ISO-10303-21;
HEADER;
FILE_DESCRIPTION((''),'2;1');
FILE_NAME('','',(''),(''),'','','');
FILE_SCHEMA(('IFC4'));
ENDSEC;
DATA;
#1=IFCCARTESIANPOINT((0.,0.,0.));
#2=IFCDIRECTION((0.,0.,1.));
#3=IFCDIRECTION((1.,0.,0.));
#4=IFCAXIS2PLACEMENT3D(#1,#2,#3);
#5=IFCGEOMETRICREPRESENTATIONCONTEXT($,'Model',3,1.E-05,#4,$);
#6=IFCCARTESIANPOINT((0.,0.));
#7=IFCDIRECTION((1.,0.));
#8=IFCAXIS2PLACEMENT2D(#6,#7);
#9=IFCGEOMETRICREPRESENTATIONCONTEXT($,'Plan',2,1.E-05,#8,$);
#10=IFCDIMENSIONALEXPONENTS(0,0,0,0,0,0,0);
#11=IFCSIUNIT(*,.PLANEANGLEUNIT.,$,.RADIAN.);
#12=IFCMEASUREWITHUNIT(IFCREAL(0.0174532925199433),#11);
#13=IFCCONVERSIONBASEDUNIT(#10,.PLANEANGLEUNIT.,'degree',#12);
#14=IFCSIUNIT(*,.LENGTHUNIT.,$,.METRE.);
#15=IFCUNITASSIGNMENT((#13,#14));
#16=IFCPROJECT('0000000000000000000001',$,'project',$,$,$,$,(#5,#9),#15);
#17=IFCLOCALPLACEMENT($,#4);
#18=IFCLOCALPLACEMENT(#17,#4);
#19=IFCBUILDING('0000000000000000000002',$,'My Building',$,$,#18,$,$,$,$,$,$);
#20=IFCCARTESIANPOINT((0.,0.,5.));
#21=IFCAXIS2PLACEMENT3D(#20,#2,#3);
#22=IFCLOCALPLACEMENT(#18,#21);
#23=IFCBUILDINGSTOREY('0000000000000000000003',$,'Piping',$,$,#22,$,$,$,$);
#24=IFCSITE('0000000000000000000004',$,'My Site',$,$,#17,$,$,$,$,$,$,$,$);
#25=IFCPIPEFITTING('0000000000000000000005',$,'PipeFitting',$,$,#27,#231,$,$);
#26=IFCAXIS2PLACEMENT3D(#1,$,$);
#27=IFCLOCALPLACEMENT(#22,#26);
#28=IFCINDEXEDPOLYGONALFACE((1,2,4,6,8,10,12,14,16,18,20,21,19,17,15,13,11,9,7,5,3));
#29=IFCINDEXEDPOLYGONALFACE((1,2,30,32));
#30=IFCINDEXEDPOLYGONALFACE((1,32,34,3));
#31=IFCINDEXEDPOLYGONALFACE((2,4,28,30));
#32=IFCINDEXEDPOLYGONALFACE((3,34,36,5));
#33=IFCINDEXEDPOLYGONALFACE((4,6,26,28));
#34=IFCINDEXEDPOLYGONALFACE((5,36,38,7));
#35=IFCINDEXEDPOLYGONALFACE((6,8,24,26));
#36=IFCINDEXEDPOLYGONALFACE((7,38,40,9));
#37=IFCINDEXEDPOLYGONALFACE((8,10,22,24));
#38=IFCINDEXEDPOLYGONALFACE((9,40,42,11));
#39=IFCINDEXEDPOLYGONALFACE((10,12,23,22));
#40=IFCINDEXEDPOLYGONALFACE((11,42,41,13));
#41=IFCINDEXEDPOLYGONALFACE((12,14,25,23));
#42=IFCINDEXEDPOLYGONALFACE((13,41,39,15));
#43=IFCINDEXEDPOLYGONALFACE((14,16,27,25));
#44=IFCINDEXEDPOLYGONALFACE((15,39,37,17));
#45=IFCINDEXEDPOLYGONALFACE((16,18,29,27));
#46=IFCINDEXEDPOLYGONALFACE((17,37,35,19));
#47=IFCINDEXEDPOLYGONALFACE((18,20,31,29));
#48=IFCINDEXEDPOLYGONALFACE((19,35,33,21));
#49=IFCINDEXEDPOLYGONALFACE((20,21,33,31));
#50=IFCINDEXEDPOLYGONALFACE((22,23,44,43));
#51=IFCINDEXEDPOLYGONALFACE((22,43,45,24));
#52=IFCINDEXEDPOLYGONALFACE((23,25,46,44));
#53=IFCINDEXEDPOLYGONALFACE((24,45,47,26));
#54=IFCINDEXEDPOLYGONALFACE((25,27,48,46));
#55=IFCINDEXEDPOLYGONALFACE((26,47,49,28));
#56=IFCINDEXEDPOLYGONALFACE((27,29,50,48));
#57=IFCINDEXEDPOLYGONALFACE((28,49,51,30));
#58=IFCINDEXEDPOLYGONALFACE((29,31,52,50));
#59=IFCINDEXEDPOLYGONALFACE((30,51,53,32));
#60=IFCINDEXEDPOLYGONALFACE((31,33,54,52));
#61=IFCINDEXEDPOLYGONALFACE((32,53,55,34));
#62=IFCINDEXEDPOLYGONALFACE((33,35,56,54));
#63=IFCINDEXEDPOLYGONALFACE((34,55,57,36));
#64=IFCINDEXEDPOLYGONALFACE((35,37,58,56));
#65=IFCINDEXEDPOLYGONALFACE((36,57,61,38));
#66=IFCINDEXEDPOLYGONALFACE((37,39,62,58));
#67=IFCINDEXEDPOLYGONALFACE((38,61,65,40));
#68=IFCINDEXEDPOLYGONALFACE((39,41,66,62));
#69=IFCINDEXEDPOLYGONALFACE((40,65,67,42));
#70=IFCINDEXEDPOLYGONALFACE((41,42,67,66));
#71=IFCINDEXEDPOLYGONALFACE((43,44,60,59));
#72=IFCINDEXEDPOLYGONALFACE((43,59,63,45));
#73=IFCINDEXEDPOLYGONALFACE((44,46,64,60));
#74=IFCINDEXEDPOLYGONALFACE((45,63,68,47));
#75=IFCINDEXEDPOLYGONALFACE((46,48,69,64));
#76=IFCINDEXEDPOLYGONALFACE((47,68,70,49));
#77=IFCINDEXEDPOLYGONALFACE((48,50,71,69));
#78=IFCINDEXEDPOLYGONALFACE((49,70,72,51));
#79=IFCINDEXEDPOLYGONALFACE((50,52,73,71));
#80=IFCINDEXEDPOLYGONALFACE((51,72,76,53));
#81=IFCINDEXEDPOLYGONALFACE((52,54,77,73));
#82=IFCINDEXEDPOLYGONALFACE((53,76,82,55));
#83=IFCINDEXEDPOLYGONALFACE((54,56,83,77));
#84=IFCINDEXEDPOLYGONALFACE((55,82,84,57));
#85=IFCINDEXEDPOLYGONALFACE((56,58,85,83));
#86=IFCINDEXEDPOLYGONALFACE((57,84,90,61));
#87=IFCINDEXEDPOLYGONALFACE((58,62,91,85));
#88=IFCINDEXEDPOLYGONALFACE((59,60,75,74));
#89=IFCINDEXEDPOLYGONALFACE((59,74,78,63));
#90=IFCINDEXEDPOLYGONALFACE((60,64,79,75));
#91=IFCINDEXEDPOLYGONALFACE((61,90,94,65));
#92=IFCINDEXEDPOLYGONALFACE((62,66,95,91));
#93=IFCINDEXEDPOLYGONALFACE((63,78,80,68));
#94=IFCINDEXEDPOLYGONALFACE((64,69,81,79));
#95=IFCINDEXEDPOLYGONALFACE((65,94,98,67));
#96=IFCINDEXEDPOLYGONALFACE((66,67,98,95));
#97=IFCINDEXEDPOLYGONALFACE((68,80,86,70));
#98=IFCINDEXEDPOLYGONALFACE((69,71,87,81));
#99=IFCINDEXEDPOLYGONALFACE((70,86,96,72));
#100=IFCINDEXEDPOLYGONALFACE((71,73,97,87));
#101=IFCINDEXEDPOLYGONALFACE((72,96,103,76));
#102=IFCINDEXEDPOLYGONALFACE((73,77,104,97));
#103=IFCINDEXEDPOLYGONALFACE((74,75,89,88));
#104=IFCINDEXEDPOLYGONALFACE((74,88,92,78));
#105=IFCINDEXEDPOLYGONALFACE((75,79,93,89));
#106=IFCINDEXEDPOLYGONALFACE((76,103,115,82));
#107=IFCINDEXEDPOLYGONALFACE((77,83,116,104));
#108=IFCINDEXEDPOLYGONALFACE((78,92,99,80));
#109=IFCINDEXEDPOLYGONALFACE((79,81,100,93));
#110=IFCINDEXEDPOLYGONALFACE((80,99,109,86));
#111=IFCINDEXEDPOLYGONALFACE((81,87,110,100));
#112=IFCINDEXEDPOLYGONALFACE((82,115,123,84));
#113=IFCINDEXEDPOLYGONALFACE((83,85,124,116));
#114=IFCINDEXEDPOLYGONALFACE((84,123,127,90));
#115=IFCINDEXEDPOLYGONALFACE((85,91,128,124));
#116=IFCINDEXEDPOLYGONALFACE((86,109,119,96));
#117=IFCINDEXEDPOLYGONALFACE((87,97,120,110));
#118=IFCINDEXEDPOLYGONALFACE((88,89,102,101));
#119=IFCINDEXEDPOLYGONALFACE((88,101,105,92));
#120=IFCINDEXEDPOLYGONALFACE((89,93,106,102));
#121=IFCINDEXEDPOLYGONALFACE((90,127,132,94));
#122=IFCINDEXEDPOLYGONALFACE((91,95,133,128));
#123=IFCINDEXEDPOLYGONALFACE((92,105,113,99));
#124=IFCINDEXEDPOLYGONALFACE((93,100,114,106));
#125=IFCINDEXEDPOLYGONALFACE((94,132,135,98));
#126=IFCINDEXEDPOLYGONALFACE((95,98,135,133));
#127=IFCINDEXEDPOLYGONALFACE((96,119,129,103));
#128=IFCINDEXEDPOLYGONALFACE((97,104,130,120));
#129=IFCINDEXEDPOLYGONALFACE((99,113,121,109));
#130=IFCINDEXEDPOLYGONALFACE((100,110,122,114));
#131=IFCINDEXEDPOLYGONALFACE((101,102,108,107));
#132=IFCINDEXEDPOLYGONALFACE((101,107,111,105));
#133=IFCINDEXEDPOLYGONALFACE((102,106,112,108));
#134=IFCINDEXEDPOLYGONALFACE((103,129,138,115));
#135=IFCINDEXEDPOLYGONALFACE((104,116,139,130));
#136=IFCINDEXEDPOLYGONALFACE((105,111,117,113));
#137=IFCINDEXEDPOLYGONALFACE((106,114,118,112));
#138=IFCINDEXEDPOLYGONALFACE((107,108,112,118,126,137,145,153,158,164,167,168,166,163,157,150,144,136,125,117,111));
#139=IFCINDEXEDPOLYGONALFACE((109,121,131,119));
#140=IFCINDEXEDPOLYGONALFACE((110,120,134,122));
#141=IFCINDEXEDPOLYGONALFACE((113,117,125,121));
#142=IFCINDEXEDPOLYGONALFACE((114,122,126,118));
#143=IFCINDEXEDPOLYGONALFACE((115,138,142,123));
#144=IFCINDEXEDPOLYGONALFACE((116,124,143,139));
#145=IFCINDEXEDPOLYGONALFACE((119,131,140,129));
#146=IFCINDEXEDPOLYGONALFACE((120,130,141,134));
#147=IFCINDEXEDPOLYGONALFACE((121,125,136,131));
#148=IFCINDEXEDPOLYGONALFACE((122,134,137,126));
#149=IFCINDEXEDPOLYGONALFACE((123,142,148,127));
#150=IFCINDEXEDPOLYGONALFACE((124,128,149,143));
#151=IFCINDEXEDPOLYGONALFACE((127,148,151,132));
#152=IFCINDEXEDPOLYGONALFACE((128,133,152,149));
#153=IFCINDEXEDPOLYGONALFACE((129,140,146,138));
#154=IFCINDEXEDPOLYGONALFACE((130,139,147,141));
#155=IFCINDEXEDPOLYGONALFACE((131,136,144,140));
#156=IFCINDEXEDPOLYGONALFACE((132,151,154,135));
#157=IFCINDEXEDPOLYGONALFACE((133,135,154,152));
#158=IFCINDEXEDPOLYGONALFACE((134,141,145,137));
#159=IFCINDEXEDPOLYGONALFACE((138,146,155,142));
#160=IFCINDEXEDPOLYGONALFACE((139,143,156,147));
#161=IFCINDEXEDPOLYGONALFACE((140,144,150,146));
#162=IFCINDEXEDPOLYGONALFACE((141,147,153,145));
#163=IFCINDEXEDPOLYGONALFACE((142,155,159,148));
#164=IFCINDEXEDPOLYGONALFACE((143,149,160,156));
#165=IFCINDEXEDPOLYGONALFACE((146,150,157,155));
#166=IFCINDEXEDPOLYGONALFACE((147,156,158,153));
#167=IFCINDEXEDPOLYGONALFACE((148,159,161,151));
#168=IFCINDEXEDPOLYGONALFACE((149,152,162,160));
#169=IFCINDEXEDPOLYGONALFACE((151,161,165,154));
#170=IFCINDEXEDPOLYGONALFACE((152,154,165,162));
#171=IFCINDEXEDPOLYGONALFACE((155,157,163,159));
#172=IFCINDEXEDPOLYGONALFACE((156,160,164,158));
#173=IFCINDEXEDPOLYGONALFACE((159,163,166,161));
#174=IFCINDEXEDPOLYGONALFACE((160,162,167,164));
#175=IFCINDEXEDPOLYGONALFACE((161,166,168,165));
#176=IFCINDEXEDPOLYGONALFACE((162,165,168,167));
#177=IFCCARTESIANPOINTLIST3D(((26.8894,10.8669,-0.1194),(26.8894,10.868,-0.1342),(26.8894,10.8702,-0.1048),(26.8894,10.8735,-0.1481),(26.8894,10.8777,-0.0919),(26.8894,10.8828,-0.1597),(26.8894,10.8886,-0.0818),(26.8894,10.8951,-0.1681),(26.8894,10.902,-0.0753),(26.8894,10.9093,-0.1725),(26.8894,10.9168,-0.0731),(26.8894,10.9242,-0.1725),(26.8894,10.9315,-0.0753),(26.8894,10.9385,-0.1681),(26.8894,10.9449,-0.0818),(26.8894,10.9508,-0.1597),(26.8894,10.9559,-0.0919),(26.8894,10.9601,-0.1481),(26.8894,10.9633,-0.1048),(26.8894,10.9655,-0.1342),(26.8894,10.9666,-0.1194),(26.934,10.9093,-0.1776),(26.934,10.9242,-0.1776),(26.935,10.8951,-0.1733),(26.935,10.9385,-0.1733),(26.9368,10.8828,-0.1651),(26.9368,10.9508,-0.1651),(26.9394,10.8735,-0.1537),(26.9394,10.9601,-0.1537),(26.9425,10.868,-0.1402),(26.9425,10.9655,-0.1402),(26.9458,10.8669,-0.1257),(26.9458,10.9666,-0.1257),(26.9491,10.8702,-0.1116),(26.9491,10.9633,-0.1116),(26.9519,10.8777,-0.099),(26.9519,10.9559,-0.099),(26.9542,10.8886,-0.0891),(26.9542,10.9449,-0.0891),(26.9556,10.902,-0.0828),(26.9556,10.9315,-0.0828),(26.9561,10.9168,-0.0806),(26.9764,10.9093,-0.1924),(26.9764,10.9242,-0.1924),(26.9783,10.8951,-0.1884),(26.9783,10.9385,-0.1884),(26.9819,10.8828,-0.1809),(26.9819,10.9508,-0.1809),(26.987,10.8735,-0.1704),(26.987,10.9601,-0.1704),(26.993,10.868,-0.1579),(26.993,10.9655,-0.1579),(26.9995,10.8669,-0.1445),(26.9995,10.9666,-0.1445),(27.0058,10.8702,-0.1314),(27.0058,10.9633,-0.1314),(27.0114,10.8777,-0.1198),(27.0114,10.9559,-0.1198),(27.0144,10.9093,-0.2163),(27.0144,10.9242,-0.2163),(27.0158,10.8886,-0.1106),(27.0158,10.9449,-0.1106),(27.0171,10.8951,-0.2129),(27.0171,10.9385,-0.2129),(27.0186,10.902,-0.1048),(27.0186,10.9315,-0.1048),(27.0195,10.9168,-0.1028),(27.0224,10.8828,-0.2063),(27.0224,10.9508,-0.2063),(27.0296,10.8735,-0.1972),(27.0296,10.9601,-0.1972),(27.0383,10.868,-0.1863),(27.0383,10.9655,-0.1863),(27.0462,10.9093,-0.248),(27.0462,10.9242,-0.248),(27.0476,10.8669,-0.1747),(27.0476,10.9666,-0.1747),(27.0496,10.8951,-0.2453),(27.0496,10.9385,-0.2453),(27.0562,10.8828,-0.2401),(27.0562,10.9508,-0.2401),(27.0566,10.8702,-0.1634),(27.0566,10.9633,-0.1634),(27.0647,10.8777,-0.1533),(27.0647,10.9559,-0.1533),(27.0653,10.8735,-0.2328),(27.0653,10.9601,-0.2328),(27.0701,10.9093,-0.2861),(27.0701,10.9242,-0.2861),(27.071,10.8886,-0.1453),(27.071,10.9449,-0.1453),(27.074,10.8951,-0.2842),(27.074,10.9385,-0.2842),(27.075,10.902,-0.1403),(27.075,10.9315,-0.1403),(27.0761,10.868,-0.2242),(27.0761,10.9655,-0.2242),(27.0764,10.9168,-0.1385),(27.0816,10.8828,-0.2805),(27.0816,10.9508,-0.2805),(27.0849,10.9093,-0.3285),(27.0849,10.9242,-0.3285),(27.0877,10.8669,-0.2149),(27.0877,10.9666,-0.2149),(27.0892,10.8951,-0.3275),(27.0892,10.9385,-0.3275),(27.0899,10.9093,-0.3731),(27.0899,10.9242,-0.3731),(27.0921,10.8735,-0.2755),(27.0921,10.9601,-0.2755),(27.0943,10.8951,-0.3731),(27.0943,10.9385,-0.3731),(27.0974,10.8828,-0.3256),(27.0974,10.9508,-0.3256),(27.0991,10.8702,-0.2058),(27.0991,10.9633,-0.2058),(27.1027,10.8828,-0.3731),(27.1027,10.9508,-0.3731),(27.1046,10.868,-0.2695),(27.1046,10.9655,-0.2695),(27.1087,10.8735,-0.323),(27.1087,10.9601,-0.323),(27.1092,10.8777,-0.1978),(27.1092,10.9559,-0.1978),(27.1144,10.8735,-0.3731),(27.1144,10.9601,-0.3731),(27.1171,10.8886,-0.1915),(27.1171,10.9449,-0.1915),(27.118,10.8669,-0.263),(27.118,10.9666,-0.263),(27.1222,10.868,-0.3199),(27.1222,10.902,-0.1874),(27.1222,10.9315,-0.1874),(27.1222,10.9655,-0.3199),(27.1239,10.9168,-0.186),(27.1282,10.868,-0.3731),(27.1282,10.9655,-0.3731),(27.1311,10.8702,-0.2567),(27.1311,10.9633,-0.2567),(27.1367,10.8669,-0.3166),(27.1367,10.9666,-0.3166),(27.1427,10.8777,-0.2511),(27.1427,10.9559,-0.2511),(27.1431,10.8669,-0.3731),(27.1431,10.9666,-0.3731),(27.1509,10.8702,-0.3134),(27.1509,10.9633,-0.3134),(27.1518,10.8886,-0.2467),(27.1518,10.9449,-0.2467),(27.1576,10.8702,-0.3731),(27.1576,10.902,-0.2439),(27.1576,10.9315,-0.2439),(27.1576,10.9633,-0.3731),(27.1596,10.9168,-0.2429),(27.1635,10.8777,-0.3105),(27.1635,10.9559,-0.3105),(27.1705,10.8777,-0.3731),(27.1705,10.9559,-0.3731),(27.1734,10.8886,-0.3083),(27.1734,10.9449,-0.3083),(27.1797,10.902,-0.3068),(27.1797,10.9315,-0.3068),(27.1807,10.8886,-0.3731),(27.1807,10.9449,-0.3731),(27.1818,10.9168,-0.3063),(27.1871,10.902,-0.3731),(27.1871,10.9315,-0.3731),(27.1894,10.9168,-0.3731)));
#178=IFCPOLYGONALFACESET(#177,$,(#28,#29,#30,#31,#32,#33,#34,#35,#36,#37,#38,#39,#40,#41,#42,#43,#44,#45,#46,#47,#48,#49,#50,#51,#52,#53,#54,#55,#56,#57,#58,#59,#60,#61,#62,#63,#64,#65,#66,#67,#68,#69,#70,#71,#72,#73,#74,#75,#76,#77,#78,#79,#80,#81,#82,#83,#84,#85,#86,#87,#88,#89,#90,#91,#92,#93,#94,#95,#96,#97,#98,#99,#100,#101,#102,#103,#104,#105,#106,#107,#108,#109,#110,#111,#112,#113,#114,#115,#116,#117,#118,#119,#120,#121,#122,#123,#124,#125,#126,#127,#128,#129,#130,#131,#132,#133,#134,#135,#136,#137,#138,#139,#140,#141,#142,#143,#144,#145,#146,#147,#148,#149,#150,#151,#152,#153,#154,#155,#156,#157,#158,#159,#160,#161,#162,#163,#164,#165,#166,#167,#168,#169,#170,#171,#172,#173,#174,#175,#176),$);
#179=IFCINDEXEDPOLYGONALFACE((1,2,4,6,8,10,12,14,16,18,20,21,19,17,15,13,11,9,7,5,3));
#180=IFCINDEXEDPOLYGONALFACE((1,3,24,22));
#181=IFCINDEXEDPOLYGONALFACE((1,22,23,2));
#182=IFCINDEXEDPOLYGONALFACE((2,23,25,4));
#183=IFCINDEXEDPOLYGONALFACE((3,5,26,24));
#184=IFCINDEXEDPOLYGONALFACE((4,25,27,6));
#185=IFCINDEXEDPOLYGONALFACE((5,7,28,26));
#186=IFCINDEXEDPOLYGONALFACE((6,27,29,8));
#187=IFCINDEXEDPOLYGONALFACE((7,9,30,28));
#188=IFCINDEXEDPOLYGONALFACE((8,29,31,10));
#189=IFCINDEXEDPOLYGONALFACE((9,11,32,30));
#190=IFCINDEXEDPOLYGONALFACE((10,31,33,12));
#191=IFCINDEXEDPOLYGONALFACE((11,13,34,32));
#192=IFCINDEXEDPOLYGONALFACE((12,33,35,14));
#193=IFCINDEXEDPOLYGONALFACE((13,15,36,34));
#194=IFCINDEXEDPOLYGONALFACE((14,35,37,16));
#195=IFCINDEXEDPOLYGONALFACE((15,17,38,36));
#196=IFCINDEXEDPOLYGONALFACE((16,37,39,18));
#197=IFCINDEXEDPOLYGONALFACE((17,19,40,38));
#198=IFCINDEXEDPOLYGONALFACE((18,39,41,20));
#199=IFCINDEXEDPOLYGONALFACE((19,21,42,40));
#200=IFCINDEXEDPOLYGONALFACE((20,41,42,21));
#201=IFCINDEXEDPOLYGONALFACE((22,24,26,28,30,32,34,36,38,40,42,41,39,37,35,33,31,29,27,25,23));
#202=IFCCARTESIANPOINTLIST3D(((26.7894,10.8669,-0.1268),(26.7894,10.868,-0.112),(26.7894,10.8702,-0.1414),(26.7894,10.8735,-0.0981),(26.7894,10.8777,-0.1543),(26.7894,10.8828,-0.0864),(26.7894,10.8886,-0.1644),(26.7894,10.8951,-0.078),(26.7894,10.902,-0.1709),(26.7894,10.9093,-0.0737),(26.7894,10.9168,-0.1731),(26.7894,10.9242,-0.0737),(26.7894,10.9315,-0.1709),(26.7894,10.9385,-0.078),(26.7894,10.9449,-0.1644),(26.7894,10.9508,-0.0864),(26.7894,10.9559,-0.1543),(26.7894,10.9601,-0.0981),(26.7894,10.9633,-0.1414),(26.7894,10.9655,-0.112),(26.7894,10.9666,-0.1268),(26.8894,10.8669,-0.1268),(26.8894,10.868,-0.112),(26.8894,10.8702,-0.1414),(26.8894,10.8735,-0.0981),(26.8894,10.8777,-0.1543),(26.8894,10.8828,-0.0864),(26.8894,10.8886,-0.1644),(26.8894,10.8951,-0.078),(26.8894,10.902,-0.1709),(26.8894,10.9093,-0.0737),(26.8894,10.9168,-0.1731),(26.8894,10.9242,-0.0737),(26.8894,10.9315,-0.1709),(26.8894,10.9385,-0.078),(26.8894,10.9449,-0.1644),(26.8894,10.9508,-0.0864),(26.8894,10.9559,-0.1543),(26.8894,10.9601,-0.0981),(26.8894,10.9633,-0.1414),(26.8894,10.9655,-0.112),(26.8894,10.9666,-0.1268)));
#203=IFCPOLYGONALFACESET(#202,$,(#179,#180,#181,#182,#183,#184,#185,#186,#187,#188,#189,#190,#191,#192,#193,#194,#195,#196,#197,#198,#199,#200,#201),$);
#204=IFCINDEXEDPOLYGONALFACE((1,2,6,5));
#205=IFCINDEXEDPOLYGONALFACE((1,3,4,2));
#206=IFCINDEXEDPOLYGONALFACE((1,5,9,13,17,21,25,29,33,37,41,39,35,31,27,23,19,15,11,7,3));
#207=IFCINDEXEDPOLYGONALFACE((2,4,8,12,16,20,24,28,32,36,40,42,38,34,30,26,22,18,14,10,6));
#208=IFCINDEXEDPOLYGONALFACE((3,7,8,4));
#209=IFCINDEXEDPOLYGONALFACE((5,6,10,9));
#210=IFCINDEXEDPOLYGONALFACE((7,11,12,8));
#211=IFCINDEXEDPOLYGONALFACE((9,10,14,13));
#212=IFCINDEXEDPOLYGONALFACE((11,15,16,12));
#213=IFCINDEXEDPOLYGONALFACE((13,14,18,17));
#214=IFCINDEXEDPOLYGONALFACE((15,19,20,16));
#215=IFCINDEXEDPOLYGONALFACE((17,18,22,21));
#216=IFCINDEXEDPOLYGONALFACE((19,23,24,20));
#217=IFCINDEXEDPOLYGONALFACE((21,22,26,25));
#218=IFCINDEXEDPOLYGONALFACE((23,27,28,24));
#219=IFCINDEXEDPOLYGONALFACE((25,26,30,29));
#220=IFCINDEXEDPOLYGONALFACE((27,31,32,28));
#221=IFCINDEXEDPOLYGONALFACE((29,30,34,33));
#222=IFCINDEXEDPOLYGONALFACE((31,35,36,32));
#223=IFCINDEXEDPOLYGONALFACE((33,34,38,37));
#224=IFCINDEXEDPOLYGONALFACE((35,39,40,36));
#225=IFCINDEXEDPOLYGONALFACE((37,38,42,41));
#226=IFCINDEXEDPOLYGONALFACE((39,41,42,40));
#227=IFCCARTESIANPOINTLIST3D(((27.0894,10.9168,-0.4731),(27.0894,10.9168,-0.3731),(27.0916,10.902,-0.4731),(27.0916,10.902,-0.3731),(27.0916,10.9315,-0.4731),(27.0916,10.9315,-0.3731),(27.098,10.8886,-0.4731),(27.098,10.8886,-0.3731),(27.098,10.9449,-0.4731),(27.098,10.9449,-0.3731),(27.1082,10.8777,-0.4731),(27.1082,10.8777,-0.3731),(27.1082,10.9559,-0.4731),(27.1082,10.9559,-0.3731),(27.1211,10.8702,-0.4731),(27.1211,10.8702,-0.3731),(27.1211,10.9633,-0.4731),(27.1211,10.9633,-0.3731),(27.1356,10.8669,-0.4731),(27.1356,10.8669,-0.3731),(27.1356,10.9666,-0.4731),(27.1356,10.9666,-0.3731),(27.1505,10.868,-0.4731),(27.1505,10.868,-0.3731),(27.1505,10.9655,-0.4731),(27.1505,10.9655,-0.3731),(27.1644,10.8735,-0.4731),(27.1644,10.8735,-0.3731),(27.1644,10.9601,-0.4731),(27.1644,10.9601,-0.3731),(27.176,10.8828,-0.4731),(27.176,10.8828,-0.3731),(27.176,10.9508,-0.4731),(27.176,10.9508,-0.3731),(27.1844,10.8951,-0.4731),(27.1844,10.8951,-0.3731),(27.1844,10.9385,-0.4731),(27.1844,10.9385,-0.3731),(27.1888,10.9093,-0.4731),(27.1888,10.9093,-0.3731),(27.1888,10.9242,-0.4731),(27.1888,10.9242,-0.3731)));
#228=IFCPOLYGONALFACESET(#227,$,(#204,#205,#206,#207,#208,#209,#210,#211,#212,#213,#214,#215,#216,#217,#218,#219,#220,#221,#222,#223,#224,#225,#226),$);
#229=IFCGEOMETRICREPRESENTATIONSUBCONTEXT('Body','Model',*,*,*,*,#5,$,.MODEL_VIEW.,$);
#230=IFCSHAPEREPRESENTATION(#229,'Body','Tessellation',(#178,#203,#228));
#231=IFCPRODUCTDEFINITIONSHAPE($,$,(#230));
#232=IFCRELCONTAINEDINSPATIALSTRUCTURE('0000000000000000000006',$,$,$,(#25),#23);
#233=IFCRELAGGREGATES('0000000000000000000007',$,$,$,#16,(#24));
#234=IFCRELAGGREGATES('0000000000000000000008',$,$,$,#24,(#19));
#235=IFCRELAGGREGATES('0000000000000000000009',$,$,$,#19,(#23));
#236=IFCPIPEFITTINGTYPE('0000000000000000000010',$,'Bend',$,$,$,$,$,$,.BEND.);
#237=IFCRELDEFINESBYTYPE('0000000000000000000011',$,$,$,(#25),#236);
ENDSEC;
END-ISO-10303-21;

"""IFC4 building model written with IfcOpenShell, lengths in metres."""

from ifc_helpers import new_model, entity, si_unit, converted_unit, frame, origin_with_axes, origin_2d_with_axis, place, context, subcontext, project, spatial, circle, extrude, source, transform, mapped, type_object, type_shapes, element, save


model = new_model("IFC4")

# Units and contexts
model_context = context("Model", 3, precision=1e-05, world=origin_with_axes())
plan_context = context("Plan", 2, precision=1e-05, world=origin_2d_with_axis())
body_context = subcontext(model_context, "Body", "Model", "MODEL_VIEW")
ifc_project = project(units=[converted_unit("PLANEANGLEUNIT", "degree", entity("IfcReal", 0.0174532925199433), si_unit("PLANEANGLEUNIT", "RADIAN"), dimensions=[0, 0, 0, 0, 0, 0, 0]), si_unit("LENGTHUNIT", "METRE")], contexts=[model_context, plan_context])

# Site, building, storey
site_placement = place(None, origin_with_axes())
site = spatial("IfcSite", under=ifc_project, at=site_placement, Name="My Site")
building_placement = place(site_placement, origin_with_axes())
building = spatial("IfcBuilding", under=site, at=building_placement, Name="My Building")
storey_placement = place(building_placement, frame((0.0, 0.0, 5.0), z_axis=(0.0, 0.0, 1.0), x_axis=(1.0, 0.0, 0.0)))
storey = spatial("IfcBuildingStorey", under=building, at=storey_placement, Name="Piping")

# Pipe fitting
pipe_fitting_type_1 = type_object("IfcPipeFittingType", Name="Bend", PredefinedType="BEND")
shared_shape = source(origin_with_axes(), body_context, "Body", "SolidModel", [
    entity("IfcSweptDiskSolid", entity("IfcIndexedPolyCurve", entity("IfcCartesianPointList3D", [[0.0, 0.0, -0.1], [0.0732, 0.0, -0.2768], [0.25, 0.0, -0.35]]), [entity("IfcArcIndex", [1, 2, 3])]), 0.05),
    extrude(circle(Radius=0.05), origin_with_axes(), (0.0, 0.0, -1.0), 0.1),
    extrude(circle(Radius=0.05), frame((0.25, 0.0, -0.35), z_axis=(1.0, 0.0, 0.0), x_axis=(0.0, 0.0, 1.0)), (0.0, 0.0, 1.0), 0.1),
])
type_shapes(pipe_fitting_type_1, [shared_shape])
for number, where, z_axis, x_axis, name in (
    (1, (26.7894, 10.9168, -0.1231), (-1.0, -0.000001, 0.0), (0.0, 0.0, -1.0), "PipeFitting"),
):
    element("IfcPipeFitting", number, at=place(storey_placement, frame(where, z_axis=z_axis, x_axis=x_axis)), inside=storey, type_object=pipe_fitting_type_1, Name=name, context=body_context, shape_type="MappedRepresentation", body=[
        mapped(shared_shape, transform((0.0, 0.0, 0.0), x_axis=(1.0, 0.0, 0.0), y_axis=(0.0, 1.0, 0.0), z_axis=(0.0, 0.0, 1.0), scale=1.0)),
    ])

save(model, "model.ifc")
